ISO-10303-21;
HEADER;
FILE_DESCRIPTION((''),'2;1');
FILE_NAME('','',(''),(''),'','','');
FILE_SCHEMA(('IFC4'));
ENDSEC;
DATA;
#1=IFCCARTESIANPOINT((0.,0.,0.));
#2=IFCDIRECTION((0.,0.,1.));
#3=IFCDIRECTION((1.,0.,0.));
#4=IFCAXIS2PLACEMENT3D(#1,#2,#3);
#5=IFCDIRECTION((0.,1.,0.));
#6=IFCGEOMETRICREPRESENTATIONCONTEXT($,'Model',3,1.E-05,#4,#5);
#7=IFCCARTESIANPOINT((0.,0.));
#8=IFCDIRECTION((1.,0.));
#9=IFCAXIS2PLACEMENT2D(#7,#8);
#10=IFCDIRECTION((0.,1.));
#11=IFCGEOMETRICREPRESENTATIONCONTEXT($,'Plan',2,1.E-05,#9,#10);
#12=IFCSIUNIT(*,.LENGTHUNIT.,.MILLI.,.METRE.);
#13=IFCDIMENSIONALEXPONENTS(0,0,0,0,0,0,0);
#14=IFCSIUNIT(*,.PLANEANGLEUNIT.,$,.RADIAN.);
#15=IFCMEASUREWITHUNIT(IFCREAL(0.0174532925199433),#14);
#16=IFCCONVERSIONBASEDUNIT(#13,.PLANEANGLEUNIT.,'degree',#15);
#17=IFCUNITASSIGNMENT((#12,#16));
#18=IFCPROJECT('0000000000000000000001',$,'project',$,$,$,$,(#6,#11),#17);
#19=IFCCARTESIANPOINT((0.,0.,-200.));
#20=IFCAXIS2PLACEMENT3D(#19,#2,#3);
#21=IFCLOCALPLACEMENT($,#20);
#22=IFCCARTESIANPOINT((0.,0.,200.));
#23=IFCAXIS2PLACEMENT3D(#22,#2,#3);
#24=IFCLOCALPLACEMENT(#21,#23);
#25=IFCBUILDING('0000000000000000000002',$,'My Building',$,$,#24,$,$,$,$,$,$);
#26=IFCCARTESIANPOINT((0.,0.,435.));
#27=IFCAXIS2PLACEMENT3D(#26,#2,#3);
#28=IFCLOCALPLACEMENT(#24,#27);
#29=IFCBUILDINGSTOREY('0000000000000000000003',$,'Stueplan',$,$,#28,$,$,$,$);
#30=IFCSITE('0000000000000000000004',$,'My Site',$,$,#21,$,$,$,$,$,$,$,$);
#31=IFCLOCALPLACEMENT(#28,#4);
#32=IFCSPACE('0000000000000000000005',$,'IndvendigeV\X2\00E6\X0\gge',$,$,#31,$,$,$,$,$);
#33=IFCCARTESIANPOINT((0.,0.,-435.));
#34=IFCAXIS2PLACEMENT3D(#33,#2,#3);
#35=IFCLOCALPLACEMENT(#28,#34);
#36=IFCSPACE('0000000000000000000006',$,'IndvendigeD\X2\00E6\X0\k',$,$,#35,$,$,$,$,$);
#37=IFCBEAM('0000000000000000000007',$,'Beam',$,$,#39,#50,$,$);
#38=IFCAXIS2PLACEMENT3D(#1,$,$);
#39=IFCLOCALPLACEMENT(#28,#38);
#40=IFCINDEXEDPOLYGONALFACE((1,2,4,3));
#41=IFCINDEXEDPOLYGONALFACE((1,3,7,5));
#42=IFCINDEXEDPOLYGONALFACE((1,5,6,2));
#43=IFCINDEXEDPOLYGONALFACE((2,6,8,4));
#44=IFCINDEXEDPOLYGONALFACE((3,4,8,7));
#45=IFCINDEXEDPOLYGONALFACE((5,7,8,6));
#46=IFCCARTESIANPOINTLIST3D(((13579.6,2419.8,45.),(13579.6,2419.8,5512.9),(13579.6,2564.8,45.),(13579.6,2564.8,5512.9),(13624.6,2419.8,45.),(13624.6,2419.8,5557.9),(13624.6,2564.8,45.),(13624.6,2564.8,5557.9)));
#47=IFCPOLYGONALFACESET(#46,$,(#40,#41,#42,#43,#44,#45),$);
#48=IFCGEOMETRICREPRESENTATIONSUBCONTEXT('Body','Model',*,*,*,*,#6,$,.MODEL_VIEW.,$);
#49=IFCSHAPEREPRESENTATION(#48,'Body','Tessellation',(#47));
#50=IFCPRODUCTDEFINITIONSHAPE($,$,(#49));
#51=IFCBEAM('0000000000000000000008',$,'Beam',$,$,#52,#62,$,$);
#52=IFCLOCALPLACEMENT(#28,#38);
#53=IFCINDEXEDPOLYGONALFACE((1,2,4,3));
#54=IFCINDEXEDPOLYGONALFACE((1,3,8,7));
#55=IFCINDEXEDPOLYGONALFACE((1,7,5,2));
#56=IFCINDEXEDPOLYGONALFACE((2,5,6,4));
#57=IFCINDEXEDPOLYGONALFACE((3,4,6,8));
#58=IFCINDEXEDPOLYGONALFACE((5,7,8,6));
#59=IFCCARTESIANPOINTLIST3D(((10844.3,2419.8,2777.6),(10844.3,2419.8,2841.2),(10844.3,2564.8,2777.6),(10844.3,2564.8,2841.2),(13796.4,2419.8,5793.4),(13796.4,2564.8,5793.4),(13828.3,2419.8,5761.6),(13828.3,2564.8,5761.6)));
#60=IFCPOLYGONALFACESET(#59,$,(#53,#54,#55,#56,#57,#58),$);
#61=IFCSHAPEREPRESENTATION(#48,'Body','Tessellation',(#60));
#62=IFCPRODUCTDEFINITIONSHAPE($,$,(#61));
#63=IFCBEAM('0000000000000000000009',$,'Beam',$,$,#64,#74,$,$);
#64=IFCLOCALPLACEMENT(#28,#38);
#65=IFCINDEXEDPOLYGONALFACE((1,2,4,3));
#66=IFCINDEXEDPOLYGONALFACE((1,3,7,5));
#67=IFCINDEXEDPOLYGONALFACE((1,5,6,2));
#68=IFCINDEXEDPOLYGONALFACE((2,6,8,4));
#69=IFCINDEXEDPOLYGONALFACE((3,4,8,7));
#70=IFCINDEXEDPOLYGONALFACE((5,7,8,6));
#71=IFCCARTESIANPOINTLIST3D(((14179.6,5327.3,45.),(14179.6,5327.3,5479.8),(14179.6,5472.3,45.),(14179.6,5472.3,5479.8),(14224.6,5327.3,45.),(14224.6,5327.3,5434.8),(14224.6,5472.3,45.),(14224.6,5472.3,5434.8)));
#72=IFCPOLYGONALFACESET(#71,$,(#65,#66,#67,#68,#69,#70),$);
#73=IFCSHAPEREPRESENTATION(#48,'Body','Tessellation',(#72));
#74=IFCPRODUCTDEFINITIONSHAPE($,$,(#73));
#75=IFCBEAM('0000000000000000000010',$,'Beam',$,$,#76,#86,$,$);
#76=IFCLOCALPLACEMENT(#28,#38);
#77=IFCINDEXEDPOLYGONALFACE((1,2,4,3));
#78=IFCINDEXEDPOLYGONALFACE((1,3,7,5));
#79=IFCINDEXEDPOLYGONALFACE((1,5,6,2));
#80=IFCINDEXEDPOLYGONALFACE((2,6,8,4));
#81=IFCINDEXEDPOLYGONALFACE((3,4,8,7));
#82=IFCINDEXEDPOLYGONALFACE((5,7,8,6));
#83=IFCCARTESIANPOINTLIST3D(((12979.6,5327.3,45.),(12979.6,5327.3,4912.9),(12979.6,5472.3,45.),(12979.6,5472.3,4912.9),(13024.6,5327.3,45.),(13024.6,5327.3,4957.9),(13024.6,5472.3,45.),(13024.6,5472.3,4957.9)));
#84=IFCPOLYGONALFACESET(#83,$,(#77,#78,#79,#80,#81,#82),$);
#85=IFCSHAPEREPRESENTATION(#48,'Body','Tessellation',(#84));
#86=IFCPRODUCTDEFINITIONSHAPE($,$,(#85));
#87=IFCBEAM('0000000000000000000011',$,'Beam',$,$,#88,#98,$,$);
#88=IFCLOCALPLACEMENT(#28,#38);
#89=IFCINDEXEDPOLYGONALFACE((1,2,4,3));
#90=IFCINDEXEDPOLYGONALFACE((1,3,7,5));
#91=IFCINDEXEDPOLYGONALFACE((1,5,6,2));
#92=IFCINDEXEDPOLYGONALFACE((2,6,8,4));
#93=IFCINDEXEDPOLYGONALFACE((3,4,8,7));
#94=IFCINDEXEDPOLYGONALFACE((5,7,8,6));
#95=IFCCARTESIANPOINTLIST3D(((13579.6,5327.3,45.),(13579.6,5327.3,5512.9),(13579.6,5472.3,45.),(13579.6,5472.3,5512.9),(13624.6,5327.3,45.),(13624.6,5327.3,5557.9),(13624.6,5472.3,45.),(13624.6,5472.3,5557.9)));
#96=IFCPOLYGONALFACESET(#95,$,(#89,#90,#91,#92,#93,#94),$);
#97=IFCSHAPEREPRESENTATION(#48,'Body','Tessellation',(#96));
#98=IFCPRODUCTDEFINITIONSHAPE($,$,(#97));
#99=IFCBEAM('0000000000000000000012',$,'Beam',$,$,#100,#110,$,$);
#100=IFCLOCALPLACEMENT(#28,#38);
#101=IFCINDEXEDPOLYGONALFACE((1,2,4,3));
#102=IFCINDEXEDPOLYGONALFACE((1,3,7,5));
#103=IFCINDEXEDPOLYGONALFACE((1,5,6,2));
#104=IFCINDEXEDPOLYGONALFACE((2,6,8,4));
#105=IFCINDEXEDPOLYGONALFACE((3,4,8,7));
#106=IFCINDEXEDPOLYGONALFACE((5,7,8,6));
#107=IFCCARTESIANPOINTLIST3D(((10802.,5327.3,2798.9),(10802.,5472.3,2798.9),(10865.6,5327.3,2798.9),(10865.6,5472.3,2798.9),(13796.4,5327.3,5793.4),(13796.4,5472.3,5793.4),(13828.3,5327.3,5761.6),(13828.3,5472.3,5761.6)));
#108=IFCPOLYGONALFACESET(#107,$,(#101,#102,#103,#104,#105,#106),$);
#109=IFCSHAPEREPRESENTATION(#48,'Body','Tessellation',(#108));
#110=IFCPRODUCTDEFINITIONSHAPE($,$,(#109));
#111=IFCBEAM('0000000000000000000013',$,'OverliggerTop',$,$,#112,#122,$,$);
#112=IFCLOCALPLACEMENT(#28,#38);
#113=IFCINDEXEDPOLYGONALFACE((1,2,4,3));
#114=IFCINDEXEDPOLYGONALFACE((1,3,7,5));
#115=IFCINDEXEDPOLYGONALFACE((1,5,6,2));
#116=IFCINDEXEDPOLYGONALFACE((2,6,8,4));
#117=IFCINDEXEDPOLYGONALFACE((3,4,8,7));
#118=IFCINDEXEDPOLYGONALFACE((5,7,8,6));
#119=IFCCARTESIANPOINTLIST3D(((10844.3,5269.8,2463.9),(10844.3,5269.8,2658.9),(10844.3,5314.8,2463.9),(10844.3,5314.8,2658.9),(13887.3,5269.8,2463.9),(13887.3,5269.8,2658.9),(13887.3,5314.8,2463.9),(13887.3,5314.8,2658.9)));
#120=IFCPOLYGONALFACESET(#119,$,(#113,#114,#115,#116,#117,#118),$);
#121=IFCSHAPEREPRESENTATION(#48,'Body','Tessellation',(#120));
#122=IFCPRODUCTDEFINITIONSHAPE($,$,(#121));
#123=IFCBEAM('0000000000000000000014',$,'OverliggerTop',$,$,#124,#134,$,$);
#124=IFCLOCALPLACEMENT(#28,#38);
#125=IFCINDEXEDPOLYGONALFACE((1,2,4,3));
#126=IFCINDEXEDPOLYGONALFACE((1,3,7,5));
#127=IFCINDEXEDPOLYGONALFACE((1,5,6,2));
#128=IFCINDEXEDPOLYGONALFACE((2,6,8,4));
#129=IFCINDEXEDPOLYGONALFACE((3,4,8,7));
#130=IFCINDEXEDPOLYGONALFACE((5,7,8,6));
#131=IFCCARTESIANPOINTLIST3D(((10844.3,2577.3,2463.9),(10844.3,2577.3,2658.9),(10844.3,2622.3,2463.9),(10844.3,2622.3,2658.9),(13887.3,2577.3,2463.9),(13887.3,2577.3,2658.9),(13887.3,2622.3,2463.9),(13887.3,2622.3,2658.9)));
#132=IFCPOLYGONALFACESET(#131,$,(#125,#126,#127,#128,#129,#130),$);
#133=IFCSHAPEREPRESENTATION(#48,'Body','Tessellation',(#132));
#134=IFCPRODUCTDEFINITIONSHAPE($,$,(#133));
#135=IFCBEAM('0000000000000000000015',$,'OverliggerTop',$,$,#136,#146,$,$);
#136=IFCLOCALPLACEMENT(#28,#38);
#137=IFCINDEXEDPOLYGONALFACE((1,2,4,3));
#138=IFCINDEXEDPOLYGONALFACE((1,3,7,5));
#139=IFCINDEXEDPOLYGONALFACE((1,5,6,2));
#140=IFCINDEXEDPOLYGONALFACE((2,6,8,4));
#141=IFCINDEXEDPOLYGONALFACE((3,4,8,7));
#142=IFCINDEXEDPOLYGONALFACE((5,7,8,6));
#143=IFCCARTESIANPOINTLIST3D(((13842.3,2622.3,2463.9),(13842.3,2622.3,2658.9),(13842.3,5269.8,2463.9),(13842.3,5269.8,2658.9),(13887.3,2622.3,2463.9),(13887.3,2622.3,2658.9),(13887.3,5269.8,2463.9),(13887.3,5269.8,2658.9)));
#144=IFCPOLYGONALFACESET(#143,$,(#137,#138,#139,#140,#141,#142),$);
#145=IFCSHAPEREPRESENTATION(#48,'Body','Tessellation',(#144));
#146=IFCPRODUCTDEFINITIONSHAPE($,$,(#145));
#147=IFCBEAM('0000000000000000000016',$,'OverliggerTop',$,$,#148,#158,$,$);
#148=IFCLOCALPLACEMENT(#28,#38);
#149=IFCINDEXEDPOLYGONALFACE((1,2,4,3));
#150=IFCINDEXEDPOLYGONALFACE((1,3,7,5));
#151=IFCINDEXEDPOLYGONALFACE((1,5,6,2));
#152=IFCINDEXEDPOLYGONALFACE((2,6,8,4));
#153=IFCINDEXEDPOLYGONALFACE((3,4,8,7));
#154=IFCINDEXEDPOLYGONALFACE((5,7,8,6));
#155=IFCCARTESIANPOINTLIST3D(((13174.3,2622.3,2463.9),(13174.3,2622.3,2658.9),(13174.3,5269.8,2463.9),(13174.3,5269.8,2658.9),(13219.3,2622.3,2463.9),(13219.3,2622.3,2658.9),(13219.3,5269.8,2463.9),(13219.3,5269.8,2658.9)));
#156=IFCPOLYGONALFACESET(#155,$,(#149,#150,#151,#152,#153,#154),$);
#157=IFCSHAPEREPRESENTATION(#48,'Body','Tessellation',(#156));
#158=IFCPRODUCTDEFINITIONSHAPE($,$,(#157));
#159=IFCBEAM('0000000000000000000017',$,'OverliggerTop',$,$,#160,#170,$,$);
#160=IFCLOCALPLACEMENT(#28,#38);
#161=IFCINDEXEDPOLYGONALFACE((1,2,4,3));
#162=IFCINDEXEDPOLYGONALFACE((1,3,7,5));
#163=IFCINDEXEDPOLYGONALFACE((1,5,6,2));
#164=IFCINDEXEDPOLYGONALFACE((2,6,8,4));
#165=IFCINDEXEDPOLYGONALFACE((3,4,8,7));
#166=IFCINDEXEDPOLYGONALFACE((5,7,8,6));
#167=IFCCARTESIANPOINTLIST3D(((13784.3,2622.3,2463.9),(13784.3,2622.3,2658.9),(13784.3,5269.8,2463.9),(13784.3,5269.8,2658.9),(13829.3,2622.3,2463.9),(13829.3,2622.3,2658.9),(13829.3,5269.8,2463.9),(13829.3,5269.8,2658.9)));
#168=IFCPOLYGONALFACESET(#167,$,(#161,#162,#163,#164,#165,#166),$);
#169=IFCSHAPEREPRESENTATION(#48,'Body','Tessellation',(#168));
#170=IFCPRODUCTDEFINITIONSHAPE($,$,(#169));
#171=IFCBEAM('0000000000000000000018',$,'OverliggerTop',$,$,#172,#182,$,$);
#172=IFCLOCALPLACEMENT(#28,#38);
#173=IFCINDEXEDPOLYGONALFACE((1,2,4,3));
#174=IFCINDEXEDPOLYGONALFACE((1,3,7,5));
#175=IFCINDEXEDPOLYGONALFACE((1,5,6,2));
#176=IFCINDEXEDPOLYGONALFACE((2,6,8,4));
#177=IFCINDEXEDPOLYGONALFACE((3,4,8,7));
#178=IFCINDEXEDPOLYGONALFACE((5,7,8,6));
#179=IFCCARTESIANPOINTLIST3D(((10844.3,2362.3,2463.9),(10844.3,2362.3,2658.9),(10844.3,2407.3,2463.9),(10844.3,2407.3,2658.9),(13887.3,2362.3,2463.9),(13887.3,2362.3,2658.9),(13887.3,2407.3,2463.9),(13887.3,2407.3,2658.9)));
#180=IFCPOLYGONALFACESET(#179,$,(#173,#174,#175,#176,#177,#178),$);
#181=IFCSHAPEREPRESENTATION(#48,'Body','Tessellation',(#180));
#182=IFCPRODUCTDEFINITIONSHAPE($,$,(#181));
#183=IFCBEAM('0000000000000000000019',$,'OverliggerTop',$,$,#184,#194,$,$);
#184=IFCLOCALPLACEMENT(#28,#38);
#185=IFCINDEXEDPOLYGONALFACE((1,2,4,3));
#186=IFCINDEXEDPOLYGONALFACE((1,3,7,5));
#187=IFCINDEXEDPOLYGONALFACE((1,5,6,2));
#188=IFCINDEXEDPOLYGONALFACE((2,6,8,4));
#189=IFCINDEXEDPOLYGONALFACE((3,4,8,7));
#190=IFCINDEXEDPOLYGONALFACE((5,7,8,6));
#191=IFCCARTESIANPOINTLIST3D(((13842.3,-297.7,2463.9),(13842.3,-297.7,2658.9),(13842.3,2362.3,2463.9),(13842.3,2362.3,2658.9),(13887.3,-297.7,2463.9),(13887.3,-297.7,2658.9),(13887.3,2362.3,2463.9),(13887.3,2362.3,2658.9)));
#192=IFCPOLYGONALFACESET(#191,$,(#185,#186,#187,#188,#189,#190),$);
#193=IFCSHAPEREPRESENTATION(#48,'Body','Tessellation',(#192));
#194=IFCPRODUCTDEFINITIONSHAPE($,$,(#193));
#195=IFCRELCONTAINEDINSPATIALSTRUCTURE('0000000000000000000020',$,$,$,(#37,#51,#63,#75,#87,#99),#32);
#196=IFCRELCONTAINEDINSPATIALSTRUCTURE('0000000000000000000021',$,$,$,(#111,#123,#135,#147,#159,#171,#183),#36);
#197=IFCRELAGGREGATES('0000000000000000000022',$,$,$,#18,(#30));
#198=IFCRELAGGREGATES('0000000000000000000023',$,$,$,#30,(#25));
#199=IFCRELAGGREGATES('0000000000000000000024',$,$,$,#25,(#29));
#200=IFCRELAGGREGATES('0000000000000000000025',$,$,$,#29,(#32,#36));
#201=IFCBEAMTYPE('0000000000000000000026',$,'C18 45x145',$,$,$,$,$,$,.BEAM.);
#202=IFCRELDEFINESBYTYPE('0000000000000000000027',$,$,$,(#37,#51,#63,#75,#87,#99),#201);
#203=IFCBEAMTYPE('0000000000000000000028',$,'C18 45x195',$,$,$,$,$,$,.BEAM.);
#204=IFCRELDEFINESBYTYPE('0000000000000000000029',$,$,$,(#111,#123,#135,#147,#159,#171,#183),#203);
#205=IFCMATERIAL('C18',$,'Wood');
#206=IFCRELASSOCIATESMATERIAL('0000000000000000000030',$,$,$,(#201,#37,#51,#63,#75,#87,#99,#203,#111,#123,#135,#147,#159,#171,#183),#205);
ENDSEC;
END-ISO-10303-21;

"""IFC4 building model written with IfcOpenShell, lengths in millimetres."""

from ifc_helpers import new_model, entity, si_unit, converted_unit, direction, frame, origin_with_axes, origin_2d_with_axis, place, context, subcontext, project, spatial, rectangle, extrude, clip, halfspace, material, material_profile, profile_set, profile_usage, type_object, element, save


model = new_model("IFC4")

# Units and contexts
model_context = context("Model", 3, precision=1e-05, world=origin_with_axes(), true_north=direction((0.0, 1.0, 0.0)))
plan_context = context("Plan", 2, precision=1e-05, world=origin_2d_with_axis(), true_north=direction((0.0, 1.0)))
body_context_1 = subcontext(model_context, "Body", "Model", "MODEL_VIEW")
ifc_project = project(units=[si_unit("LENGTHUNIT", "METRE", prefix="MILLI"), converted_unit("PLANEANGLEUNIT", "degree", entity("IfcReal", 0.0174532925199433), si_unit("PLANEANGLEUNIT", "RADIAN"), dimensions=[0, 0, 0, 0, 0, 0, 0])], contexts=[model_context, plan_context])

# Site, building, storey
site_placement = place(None, frame((0.0, 0.0, -200.0), z_axis=(0.0, 0.0, 1.0), x_axis=(1.0, 0.0, 0.0)))
site = spatial("IfcSite", under=ifc_project, at=site_placement, Name="My Site")
building_placement = place(site_placement, frame((0.0, 0.0, 200.0), z_axis=(0.0, 0.0, 1.0), x_axis=(1.0, 0.0, 0.0)))
building = spatial("IfcBuilding", under=site, at=building_placement, Name="My Building")
storey_placement = place(building_placement, frame((0.0, 0.0, 435.0), z_axis=(0.0, 0.0, 1.0), x_axis=(1.0, 0.0, 0.0)))
storey = spatial("IfcBuildingStorey", under=building, at=storey_placement, Name="Stueplan")

# Shared definitions
ifc_material = material(Name="C18", Category="Wood")

# Shared definitions
space_1_placement = place(storey_placement, frame((0.0, 0.0, 0.0), z_axis=(0.0, 0.0, 1.0), x_axis=(1.0, 0.0, 0.0)))
space_1 = spatial("IfcSpace", under=storey, at=space_1_placement, Name="IndvendigeVægge")

# Beams
ifc_material_profile_1 = material_profile(ifc_material, rectangle(XDim=45.0, YDim=145.0))
ifc_profile_set_1 = profile_set([ifc_material_profile_1], Name="woodStructural")
beam_type_1 = type_object("IfcBeamType", Name="C18 45x145", PredefinedType="BEAM", material=ifc_profile_set_1)
ifc_profile_usage_1 = profile_usage(ifc_profile_set_1)
beam_1_placement = place(space_1_placement, frame((13602.1, 2492.3, 45.0), z_axis=(0.0, 0.0, 1.0), x_axis=(-1.0, 0.0, 0.0)))
element("IfcBeam", 1, at=beam_1_placement, inside=space_1, type_object=beam_type_1, material=ifc_profile_usage_1, Name="Beam", context=body_context_1, shape_type="Clipping", body=[
    clip(extrude(rectangle(XDim=45.0, YDim=145.0), origin_with_axes(), (0.0, 0.0, 1.0), 5635.4), halfspace(frame((-239.0, 0.0, 5729.4), z_axis=(0.707107, 0.0, 0.707107), x_axis=(0.0, -1.0, 0.0)), False)),
])
ifc_profile_usage_2 = profile_usage(ifc_profile_set_1)
beam_2_placement = place(space_1_placement, frame((13812.3, 2492.3, 5777.5), z_axis=(-0.707107, 0.0, -0.707107), x_axis=(0.707107, 0.0, -0.707107)))
element("IfcBeam", 2, at=beam_2_placement, inside=space_1, type_object=beam_type_1, material=ifc_profile_usage_2, Name="Beam", context=body_context_1, shape_type="Clipping", body=[
    clip(extrude(rectangle(XDim=45.0, YDim=145.0), origin_with_axes(), (0.0, 0.0, 1.0), 4342.5), halfspace(frame((22.6, 2919.8, 4220.1), z_axis=(-0.707107, 0.0, 0.707107), x_axis=(0.0, 1.0, 0.0)), False)),
])
ifc_profile_usage_3 = profile_usage(ifc_profile_set_1)
beam_3_placement = place(space_1_placement, frame((14202.1, 5399.8, 45.0), z_axis=(0.0, 0.0, 1.0), x_axis=(-1.0, 0.0, 0.0)))
element("IfcBeam", 3, at=beam_3_placement, inside=space_1, type_object=beam_type_1, material=ifc_profile_usage_3, Name="Beam", context=body_context_1, shape_type="Clipping", body=[
    clip(extrude(rectangle(XDim=45.0, YDim=145.0), origin_with_axes(), (0.0, 0.0, 1.0), 5557.3), halfspace(frame((-2768.8, 0.0, 2643.4), z_axis=(-0.707107, 0.0, 0.707106), x_axis=(0.0, 1.0, 0.0)), False)),
])
ifc_profile_usage_4 = profile_usage(ifc_profile_set_1)
beam_4_placement = place(space_1_placement, frame((13002.1, 5399.8, 45.0), z_axis=(0.0, 0.0, 1.0), x_axis=(-1.0, 0.0, 0.0)))
element("IfcBeam", 4, at=beam_4_placement, inside=space_1, type_object=beam_type_1, material=ifc_profile_usage_4, Name="Beam", context=body_context_1, shape_type="Clipping", body=[
    clip(extrude(rectangle(XDim=45.0, YDim=145.0), origin_with_axes(), (0.0, 0.0, 1.0), 5035.4), halfspace(frame((-839.0, 0.0, 5729.4), z_axis=(0.707107, 0.0, 0.707107), x_axis=(0.0, -1.0, 0.0)), False)),
])
ifc_profile_usage_5 = profile_usage(ifc_profile_set_1)
beam_5_placement = place(space_1_placement, frame((13602.1, 5399.8, 45.0), z_axis=(0.0, 0.0, 1.0), x_axis=(-1.0, 0.0, 0.0)))
element("IfcBeam", 5, at=beam_5_placement, inside=space_1, type_object=beam_type_1, material=ifc_profile_usage_5, Name="Beam", context=body_context_1, shape_type="Clipping", body=[
    clip(extrude(rectangle(XDim=45.0, YDim=145.0), origin_with_axes(), (0.0, 0.0, 1.0), 5635.4), halfspace(frame((-239.0, 0.0, 5729.4), z_axis=(0.707107, 0.0, 0.707107), x_axis=(0.0, -1.0, 0.0)), False)),
])
ifc_profile_usage_6 = profile_usage(ifc_profile_set_1)
beam_6_placement = place(space_1_placement, frame((13812.3, 5399.8, 5777.5), z_axis=(-0.707107, 0.0, -0.707107), x_axis=(0.707107, 0.0, -0.707107)))
element("IfcBeam", 6, at=beam_6_placement, inside=space_1, type_object=beam_type_1, material=ifc_profile_usage_6, Name="Beam", context=body_context_1, shape_type="Clipping", body=[
    clip(extrude(rectangle(XDim=45.0, YDim=145.0), origin_with_axes(), (0.0, 0.0, 1.0), 4357.3), halfspace(frame((7.4, 0.0, 4204.9), z_axis=(0.707107, 0.0, 0.707107), x_axis=(0.0, -1.0, 0.0)), False)),
])

# Shared definitions
space_2_placement = place(storey_placement, frame((0.0, 0.0, -435.0), z_axis=(0.0, 0.0, 1.0), x_axis=(1.0, 0.0, 0.0)))
space_2 = spatial("IfcSpace", under=storey, at=space_2_placement, Name="IndvendigeDæk")

# Beams
ifc_material_profile_2 = material_profile(ifc_material, rectangle(XDim=45.0, YDim=195.0))
ifc_profile_set_2 = profile_set([ifc_material_profile_2], Name="woodStructural")
ifc_profile_usage_7 = profile_usage(ifc_profile_set_2)
beam_type_2 = type_object("IfcBeamType", Name="C18 45x195", PredefinedType="BEAM", material=ifc_profile_set_2)
beam_7_placement = place(space_2_placement, frame((13887.3, 5292.3, 2996.4), z_axis=(-1.0, 0.0, 0.0), x_axis=(0.0, 1.0, 0.0)))
element("IfcBeam", 7, at=beam_7_placement, inside=space_2, type_object=beam_type_2, material=ifc_profile_usage_7, Name="OverliggerTop", context=body_context_1, shape_type="SweptSolid", body=[
    extrude(rectangle(XDim=45.0, YDim=195.0), origin_with_axes(), (0.0, 0.0, 1.0), 3043.0),
])
ifc_profile_usage_8 = profile_usage(ifc_profile_set_2)
beam_8_placement = place(space_2_placement, frame((13887.3, 2599.8, 2996.4), z_axis=(-1.0, 0.0, 0.0), x_axis=(0.0, 1.0, 0.0)))
element("IfcBeam", 8, at=beam_8_placement, inside=space_2, type_object=beam_type_2, material=ifc_profile_usage_8, Name="OverliggerTop", context=body_context_1, shape_type="SweptSolid", body=[
    extrude(rectangle(XDim=45.0, YDim=195.0), origin_with_axes(), (0.0, 0.0, 1.0), 3043.0),
])
ifc_profile_usage_9 = profile_usage(ifc_profile_set_2)
beam_9_placement = place(space_2_placement, frame((13864.8, 5269.8, 2996.4), z_axis=(0.000001, -1.0, 0.0), x_axis=(-1.0, -0.000001, 0.0)))
element("IfcBeam", 9, at=beam_9_placement, inside=space_2, type_object=beam_type_2, material=ifc_profile_usage_9, Name="OverliggerTop", context=body_context_1, shape_type="SweptSolid", body=[
    extrude(rectangle(XDim=45.0, YDim=195.0), origin_with_axes(), (0.0, 0.0, 1.0), 2647.5),
])
ifc_profile_usage_10 = profile_usage(ifc_profile_set_2)
beam_10_placement = place(space_2_placement, frame((13196.8, 5269.8, 2996.4), z_axis=(0.000001, -1.0, 0.0), x_axis=(-1.0, -0.000001, 0.0)))
element("IfcBeam", 10, at=beam_10_placement, inside=space_2, type_object=beam_type_2, material=ifc_profile_usage_10, Name="OverliggerTop", context=body_context_1, shape_type="SweptSolid", body=[
    extrude(rectangle(XDim=45.0, YDim=195.0), origin_with_axes(), (0.0, 0.0, 1.0), 2647.5),
])
ifc_profile_usage_11 = profile_usage(ifc_profile_set_2)
beam_11_placement = place(space_2_placement, frame((13806.8, 5269.8, 2996.4), z_axis=(0.000001, -1.0, 0.0), x_axis=(-1.0, -0.000001, 0.0)))
element("IfcBeam", 11, at=beam_11_placement, inside=space_2, type_object=beam_type_2, material=ifc_profile_usage_11, Name="OverliggerTop", context=body_context_1, shape_type="SweptSolid", body=[
    extrude(rectangle(XDim=45.0, YDim=195.0), origin_with_axes(), (0.0, 0.0, 1.0), 2647.5),
])
ifc_profile_usage_12 = profile_usage(ifc_profile_set_2)
beam_12_placement = place(space_2_placement, frame((13887.3, 2384.8, 2996.4), z_axis=(-1.0, 0.0, 0.0), x_axis=(0.0, 1.0, 0.0)))
element("IfcBeam", 12, at=beam_12_placement, inside=space_2, type_object=beam_type_2, material=ifc_profile_usage_12, Name="OverliggerTop", context=body_context_1, shape_type="SweptSolid", body=[
    extrude(rectangle(XDim=45.0, YDim=195.0), origin_with_axes(), (0.0, 0.0, 1.0), 3043.0),
])
ifc_profile_usage_13 = profile_usage(ifc_profile_set_2)
beam_13_placement = place(space_2_placement, frame((13864.8, 2362.3, 2996.4), z_axis=(0.000001, -1.0, 0.0), x_axis=(-1.0, -0.000001, 0.0)))
element("IfcBeam", 13, at=beam_13_placement, inside=space_2, type_object=beam_type_2, material=ifc_profile_usage_13, Name="OverliggerTop", context=body_context_1, shape_type="SweptSolid", body=[
    extrude(rectangle(XDim=45.0, YDim=195.0), origin_with_axes(), (0.0, 0.0, 1.0), 2660.0),
])

save(model, "model.ifc")
